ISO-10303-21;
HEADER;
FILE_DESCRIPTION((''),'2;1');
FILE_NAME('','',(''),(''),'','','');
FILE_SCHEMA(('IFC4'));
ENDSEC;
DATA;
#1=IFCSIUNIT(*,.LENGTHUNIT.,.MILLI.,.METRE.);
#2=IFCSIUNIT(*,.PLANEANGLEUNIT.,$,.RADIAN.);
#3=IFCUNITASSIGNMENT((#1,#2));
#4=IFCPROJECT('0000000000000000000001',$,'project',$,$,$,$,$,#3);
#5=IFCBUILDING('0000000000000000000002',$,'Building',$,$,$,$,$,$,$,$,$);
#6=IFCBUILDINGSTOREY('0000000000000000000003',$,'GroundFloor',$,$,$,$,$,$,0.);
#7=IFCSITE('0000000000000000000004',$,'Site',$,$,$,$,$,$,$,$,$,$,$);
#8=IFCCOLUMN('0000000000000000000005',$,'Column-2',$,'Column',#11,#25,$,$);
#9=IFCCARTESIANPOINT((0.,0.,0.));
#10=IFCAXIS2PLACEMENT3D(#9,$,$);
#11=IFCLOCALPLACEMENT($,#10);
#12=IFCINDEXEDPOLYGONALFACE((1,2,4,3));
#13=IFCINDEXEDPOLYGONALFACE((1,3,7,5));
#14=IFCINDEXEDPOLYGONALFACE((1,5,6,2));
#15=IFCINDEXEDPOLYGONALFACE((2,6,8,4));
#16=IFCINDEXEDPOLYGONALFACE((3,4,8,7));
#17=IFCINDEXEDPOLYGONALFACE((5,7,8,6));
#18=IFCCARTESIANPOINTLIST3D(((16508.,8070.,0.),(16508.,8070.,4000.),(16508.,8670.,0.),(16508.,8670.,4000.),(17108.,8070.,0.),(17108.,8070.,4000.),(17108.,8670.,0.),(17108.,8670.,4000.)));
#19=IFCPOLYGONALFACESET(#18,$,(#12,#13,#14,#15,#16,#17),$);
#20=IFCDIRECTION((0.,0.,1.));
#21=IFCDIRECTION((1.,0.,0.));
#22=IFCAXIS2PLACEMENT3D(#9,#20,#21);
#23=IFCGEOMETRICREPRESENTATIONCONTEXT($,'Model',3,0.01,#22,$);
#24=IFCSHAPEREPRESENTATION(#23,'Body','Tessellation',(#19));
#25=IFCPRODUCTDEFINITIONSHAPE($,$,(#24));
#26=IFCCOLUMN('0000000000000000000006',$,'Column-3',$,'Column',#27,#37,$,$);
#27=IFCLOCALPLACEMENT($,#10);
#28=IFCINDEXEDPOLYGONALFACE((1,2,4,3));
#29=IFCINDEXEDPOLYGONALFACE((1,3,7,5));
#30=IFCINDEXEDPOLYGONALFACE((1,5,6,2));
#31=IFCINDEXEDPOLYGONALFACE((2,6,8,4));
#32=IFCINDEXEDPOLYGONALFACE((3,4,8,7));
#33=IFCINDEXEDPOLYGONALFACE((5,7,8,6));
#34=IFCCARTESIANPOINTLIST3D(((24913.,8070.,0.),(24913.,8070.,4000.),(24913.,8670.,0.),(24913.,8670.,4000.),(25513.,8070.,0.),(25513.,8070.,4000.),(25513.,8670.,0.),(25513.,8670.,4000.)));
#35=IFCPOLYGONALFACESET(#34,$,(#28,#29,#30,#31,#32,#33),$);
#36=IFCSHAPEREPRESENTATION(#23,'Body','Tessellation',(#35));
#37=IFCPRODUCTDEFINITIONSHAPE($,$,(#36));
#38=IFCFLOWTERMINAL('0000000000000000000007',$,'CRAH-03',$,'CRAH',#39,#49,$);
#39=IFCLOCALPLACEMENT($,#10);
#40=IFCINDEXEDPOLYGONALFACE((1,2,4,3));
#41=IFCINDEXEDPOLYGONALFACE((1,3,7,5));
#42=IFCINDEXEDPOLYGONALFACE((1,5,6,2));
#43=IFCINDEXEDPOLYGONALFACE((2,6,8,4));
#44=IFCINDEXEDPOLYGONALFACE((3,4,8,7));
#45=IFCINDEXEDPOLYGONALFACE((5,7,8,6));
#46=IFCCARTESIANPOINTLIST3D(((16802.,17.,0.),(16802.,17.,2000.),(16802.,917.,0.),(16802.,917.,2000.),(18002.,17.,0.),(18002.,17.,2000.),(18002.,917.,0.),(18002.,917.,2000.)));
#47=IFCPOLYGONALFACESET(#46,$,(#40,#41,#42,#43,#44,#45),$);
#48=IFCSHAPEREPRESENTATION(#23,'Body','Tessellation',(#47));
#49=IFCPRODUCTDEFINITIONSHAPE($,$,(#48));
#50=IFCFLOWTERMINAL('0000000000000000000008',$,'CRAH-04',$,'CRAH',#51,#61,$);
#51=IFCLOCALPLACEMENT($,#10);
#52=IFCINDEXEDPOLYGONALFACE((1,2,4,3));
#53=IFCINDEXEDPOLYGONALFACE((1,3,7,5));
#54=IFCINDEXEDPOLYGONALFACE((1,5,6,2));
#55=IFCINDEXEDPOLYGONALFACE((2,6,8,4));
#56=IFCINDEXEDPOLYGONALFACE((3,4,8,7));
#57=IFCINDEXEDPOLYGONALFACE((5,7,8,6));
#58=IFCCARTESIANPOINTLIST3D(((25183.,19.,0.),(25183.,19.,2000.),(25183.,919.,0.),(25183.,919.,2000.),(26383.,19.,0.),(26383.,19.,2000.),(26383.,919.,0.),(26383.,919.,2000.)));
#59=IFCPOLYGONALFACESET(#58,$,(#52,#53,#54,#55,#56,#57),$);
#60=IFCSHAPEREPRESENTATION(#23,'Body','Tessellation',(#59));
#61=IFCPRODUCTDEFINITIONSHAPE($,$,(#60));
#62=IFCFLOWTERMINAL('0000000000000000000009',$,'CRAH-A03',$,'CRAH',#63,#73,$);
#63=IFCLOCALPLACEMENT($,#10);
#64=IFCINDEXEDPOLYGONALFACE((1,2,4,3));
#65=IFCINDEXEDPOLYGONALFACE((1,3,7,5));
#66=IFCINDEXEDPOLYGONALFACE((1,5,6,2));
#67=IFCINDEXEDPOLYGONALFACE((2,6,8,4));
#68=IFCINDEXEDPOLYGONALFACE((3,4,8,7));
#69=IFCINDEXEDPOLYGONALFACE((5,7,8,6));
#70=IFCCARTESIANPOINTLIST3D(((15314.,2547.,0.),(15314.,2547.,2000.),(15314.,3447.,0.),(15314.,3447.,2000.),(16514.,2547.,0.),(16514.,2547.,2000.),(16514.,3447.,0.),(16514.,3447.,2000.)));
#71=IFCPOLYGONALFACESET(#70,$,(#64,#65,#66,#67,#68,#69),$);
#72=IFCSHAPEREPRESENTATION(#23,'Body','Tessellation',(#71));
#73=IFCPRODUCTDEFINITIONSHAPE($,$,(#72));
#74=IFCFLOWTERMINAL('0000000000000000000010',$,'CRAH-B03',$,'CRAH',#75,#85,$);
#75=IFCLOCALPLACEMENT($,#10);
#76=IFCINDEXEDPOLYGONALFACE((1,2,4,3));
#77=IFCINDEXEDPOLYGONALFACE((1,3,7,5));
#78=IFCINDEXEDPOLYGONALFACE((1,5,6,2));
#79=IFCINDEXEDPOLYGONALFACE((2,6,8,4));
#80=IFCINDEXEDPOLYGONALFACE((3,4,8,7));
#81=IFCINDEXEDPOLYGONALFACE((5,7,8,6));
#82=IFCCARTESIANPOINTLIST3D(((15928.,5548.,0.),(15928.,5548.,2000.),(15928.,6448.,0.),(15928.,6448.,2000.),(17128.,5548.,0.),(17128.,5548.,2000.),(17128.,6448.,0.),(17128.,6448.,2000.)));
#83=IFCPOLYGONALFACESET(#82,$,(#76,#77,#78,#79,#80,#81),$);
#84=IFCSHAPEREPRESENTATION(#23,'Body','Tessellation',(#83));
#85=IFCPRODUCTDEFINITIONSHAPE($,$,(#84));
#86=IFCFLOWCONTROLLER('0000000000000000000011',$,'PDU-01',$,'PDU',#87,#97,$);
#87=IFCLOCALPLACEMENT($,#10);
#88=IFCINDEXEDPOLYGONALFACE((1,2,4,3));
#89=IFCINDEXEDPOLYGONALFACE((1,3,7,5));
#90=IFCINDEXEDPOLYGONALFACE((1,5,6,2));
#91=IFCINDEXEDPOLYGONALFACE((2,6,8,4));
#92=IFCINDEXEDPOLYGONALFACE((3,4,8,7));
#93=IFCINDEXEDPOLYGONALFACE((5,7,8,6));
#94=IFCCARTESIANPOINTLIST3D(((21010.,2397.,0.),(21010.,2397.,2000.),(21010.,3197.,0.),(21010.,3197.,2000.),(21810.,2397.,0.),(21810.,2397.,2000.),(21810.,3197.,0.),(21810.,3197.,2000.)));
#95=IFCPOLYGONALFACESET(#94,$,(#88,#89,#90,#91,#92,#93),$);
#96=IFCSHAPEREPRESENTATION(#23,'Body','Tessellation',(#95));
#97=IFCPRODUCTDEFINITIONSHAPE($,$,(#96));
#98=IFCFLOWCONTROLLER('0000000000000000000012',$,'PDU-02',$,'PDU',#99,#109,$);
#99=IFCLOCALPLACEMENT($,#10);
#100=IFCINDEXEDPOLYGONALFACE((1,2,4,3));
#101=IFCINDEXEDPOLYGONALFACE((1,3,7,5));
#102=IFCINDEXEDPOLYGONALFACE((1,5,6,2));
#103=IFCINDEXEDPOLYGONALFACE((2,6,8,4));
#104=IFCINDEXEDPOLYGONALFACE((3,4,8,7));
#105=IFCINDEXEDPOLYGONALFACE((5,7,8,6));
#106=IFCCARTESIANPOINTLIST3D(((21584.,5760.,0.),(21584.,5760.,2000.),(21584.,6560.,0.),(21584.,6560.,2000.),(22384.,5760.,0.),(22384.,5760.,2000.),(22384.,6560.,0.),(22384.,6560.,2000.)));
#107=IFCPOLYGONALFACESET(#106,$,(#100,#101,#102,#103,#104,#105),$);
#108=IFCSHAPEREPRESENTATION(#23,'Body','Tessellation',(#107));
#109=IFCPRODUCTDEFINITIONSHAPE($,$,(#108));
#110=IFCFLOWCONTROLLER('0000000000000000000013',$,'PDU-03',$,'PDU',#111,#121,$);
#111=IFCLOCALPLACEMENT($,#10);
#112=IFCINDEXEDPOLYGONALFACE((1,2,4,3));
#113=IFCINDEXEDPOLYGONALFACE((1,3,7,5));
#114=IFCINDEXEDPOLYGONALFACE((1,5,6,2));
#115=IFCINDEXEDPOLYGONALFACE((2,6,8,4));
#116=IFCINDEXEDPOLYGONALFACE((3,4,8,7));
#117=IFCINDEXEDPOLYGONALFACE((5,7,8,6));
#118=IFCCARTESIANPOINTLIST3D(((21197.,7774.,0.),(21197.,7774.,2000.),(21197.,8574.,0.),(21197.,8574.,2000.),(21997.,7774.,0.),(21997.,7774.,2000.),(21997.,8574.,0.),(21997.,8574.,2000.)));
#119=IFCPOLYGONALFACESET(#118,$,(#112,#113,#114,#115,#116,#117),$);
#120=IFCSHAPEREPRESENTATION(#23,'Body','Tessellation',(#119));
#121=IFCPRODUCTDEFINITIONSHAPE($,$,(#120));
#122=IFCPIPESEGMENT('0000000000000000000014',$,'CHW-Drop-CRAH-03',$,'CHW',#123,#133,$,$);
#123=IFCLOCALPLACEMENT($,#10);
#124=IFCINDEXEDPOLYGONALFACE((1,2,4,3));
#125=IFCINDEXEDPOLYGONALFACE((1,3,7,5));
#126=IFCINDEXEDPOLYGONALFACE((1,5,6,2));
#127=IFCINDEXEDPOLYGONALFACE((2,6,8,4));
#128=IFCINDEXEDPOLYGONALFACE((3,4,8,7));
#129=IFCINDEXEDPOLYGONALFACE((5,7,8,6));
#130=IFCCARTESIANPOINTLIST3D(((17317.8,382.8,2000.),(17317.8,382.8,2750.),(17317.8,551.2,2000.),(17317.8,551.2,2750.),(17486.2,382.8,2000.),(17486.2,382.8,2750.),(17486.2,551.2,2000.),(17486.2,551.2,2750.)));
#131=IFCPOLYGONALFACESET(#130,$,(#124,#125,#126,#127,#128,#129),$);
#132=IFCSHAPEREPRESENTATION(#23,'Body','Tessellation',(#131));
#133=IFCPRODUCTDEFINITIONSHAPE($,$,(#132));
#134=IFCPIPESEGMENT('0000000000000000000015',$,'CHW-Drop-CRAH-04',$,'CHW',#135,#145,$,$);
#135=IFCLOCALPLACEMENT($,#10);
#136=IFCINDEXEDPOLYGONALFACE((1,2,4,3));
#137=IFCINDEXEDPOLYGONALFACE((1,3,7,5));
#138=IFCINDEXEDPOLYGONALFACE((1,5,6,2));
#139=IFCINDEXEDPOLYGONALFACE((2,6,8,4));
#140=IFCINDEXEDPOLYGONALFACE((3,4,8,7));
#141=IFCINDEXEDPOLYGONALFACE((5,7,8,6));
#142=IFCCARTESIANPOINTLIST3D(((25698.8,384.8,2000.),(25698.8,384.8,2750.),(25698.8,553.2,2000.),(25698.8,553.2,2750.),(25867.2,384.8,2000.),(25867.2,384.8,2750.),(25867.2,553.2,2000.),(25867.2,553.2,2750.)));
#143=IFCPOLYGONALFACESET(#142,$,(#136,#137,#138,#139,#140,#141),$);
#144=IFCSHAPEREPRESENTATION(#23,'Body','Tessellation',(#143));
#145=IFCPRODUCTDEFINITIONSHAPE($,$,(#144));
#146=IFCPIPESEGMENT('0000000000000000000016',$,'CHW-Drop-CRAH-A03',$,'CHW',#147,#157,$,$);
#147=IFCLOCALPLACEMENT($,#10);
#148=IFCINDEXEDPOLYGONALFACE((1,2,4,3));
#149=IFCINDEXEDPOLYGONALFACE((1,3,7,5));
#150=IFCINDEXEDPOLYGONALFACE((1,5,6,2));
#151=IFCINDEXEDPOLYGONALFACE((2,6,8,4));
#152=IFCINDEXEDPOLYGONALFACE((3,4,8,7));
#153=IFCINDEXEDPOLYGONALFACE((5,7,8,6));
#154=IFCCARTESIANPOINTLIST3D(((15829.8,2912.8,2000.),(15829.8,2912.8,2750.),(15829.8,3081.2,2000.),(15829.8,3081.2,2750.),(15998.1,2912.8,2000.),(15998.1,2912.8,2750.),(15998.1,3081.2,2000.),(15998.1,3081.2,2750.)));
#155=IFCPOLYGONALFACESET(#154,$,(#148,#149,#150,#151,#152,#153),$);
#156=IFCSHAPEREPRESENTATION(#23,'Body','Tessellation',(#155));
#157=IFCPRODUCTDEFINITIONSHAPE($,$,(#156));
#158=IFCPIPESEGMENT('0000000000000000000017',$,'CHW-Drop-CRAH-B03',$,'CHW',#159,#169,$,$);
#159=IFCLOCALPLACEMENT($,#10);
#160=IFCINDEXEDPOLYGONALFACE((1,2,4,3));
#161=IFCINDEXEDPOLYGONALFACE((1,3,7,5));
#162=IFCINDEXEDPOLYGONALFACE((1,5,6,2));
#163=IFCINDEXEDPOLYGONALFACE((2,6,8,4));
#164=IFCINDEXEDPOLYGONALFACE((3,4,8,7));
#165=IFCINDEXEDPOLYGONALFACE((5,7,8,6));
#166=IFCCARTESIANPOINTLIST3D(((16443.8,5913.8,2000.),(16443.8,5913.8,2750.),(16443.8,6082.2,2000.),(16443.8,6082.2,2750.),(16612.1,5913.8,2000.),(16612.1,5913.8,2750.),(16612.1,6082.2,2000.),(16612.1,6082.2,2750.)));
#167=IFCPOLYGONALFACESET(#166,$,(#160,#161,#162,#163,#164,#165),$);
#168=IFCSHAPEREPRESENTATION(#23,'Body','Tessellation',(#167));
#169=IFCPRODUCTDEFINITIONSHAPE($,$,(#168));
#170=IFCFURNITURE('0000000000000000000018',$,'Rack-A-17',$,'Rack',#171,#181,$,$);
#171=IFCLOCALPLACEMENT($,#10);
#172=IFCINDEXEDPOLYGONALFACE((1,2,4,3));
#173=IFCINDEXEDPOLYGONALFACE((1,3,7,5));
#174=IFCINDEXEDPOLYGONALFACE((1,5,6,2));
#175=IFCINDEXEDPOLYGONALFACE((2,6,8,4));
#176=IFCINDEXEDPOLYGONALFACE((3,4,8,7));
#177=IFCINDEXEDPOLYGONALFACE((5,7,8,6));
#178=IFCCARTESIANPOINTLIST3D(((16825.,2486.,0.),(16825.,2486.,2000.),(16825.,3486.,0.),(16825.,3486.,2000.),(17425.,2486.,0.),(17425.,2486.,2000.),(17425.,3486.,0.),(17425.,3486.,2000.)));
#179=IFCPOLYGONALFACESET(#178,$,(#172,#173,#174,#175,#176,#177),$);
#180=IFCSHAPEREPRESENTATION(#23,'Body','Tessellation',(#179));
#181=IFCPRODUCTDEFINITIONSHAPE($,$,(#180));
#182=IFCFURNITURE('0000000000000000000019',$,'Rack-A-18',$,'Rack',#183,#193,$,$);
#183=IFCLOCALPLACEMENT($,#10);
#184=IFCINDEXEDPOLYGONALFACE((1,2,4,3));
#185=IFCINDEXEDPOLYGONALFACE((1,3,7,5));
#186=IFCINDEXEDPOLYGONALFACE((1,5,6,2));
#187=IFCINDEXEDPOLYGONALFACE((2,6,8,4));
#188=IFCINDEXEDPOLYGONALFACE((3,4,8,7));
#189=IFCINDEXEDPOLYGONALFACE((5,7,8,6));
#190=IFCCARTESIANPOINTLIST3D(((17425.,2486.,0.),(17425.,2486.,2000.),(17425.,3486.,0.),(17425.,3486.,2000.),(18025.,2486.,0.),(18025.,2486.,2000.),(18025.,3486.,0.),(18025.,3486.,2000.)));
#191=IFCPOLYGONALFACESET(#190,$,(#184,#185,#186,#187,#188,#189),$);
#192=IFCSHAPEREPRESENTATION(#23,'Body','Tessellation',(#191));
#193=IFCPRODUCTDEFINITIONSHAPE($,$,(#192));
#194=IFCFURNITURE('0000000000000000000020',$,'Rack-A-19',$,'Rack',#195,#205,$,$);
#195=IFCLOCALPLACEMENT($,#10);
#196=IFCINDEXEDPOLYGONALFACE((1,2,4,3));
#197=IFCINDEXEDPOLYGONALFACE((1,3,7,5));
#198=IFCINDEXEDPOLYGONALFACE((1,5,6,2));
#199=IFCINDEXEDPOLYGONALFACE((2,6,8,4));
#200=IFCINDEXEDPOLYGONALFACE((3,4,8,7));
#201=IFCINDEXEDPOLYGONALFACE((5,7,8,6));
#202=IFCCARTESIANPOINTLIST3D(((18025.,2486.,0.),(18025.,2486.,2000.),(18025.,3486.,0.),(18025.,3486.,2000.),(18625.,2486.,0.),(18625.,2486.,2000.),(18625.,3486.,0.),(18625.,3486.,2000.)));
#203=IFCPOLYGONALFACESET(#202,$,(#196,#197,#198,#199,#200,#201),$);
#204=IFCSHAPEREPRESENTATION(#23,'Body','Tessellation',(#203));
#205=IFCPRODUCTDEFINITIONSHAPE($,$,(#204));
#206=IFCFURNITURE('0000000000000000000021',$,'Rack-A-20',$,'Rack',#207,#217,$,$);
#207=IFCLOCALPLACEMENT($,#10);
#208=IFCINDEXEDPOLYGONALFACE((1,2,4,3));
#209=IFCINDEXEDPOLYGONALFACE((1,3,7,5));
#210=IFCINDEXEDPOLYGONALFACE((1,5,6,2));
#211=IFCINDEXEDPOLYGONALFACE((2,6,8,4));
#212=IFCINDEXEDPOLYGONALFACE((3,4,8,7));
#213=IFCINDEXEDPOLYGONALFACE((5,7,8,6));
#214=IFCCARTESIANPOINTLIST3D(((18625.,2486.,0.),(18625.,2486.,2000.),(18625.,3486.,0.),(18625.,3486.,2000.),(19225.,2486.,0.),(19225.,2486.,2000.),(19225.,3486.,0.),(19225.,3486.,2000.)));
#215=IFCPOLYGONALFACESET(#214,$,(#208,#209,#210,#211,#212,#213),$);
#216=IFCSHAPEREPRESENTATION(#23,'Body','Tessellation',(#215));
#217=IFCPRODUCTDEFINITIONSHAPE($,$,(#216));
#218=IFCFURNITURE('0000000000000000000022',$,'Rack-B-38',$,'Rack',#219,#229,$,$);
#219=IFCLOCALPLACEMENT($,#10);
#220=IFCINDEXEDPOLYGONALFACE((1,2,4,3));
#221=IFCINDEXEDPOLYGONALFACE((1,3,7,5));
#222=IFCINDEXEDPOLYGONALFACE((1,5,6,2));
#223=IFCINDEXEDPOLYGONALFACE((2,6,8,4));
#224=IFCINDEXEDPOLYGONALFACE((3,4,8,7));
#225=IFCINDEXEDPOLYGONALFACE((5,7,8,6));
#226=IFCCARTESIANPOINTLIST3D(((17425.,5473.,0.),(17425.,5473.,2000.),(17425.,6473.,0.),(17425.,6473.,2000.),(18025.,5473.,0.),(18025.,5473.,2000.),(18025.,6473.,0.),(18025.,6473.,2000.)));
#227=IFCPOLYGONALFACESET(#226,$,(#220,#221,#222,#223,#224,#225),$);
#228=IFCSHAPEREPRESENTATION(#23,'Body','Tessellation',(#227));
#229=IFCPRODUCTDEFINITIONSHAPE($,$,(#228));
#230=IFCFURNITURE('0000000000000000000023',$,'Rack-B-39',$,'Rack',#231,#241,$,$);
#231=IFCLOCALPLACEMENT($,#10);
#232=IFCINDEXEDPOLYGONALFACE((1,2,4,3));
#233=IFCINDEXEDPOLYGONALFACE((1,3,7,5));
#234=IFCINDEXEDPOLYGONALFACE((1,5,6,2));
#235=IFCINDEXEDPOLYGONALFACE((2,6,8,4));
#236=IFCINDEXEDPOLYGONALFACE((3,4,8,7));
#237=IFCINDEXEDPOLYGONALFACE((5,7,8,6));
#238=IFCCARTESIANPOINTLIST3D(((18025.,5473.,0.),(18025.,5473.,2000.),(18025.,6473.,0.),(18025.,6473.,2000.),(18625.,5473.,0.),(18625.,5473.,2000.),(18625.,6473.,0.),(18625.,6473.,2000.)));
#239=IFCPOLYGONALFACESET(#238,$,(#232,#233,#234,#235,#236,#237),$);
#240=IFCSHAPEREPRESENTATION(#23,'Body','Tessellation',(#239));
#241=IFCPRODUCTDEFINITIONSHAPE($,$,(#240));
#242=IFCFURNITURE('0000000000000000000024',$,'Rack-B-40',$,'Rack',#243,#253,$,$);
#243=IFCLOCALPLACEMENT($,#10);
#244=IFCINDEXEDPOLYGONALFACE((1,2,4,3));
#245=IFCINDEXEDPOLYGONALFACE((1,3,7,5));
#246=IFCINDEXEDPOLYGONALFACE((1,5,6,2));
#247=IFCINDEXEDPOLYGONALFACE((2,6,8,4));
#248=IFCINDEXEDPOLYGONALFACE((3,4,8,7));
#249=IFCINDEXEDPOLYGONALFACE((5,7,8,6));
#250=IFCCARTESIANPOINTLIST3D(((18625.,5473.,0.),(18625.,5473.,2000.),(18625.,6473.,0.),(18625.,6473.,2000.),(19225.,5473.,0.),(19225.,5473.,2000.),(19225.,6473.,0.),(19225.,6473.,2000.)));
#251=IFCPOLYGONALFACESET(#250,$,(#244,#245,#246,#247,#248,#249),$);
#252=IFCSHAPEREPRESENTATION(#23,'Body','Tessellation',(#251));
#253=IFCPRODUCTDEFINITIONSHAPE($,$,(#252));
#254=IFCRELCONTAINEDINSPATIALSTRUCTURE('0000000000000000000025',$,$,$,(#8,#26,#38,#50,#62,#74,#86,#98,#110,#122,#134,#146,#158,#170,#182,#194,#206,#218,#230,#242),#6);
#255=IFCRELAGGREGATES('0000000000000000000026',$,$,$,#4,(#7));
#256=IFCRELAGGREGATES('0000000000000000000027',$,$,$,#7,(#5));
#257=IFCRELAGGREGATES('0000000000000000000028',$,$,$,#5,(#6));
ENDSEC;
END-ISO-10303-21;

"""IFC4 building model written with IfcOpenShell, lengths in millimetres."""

from ifc_helpers import new_model, si_unit, frame, origin, origin_with_axes, origin_2d, place, context, project, spatial, rectangle, extrude, element, save


model = new_model("IFC4")

# Units and contexts
model_context = context("Model", 3, precision=0.01, world=origin_with_axes())
ifc_project = project(units=[si_unit("LENGTHUNIT", "METRE", prefix="MILLI"), si_unit("PLANEANGLEUNIT", "RADIAN")])

# Site, building, storey
site = spatial("IfcSite", under=ifc_project, Name="Site")
building = spatial("IfcBuilding", under=site, Name="Building")
storey = spatial("IfcBuildingStorey", under=building, Name="GroundFloor", Elevation=0.0)

# Columns
for number, where, z_axis, x_axis, name in (
    (1, (16808.0, 8370.0, 0.0), (0.0, 0.0, 1.0), (1.0, 0.0, 0.0), "Column-2"),
    (2, (25213.0, 8370.0, 0.0), (0.0, 0.0, 1.0), (1.0, 0.0, 0.0), "Column-3"),
):
    element("IfcColumn", number, at=place(None, frame(where, z_axis=z_axis, x_axis=x_axis)), inside=storey, Name=name, ObjectType="Column", context=model_context, shape_type="SweptSolid", body=[
        extrude(rectangle(XDim=600.0, YDim=600.0, at=origin_2d()), origin(), (0.0, 0.0, 1.0), 4000.0),
    ])

# Flow terminals
for number, where, z_axis, x_axis, name in (
    (3, (17402.0, 467.0, 0.0), (0.0, 0.0, 1.0), (1.0, 0.0, 0.0), "CRAH-03"),
    (4, (25783.0, 469.0, 0.0), (0.0, 0.0, 1.0), (1.0, 0.0, 0.0), "CRAH-04"),
    (5, (15914.0, 2997.0, 0.0), (0.0, 0.0, 1.0), (1.0, 0.0, 0.0), "CRAH-A03"),
    (6, (16528.0, 5998.0, 0.0), (0.0, 0.0, 1.0), (1.0, 0.0, 0.0), "CRAH-B03"),
):
    element("IfcFlowTerminal", number, at=place(None, frame(where, z_axis=z_axis, x_axis=x_axis)), inside=storey, Name=name, ObjectType="CRAH", context=model_context, shape_type="SweptSolid", body=[
        extrude(rectangle(XDim=1200.0, YDim=900.0, at=origin_2d()), origin(), (0.0, 0.0, 1.0), 2000.0),
    ])

# Flow controllers
for number, where, z_axis, x_axis, name in (
    (7, (21410.0, 2797.0, 0.0), (0.0, 0.0, 1.0), (1.0, 0.0, 0.0), "PDU-01"),
    (8, (21984.0, 6160.0, 0.0), (0.0, 0.0, 1.0), (1.0, 0.0, 0.0), "PDU-02"),
    (9, (21597.0, 8174.0, 0.0), (0.0, 0.0, 1.0), (1.0, 0.0, 0.0), "PDU-03"),
):
    element("IfcFlowController", number, at=place(None, frame(where, z_axis=z_axis, x_axis=x_axis)), inside=storey, Name=name, ObjectType="PDU", context=model_context, shape_type="SweptSolid", body=[
        extrude(rectangle(XDim=800.0, YDim=800.0, at=origin_2d()), origin(), (0.0, 0.0, 1.0), 2000.0),
    ])

# Pipe segments
for number, where, z_axis, x_axis, name in (
    (10, (17402.0, 467.0, 2000.0), (0.0, 0.0, 1.0), (1.0, 0.0, 0.0), "CHW-Drop-CRAH-03"),
    (11, (25783.0, 469.0, 2000.0), (0.0, 0.0, 1.0), (1.0, 0.0, 0.0), "CHW-Drop-CRAH-04"),
    (12, (15914.0, 2997.0, 2000.0), (0.0, 0.0, 1.0), (1.0, 0.0, 0.0), "CHW-Drop-CRAH-A03"),
    (13, (16528.0, 5998.0, 2000.0), (0.0, 0.0, 1.0), (1.0, 0.0, 0.0), "CHW-Drop-CRAH-B03"),
):
    element("IfcPipeSegment", number, at=place(None, frame(where, z_axis=z_axis, x_axis=x_axis)), inside=storey, Name=name, ObjectType="CHW", context=model_context, shape_type="SweptSolid", body=[
        extrude(rectangle(XDim=168.3, YDim=168.3, at=origin_2d()), origin(), (0.0, 0.0, 1.0), 750.0),
    ])

# Furniture
for number, where, z_axis, x_axis, name in (
    (14, (17125.0, 2986.0, 0.0), (0.0, 0.0, 1.0), (1.0, 0.0, 0.0), "Rack-A-17"),
    (15, (17725.0, 2986.0, 0.0), (0.0, 0.0, 1.0), (1.0, 0.0, 0.0), "Rack-A-18"),
    (16, (18325.0, 2986.0, 0.0), (0.0, 0.0, 1.0), (1.0, 0.0, 0.0), "Rack-A-19"),
    (17, (18925.0, 2986.0, 0.0), (0.0, 0.0, 1.0), (1.0, 0.0, 0.0), "Rack-A-20"),
    (18, (17725.0, 5973.0, 0.0), (0.0, 0.0, 1.0), (1.0, 0.0, 0.0), "Rack-B-38"),
    (19, (18325.0, 5973.0, 0.0), (0.0, 0.0, 1.0), (1.0, 0.0, 0.0), "Rack-B-39"),
    (20, (18925.0, 5973.0, 0.0), (0.0, 0.0, 1.0), (1.0, 0.0, 0.0), "Rack-B-40"),
):
    element("IfcFurniture", number, at=place(None, frame(where, z_axis=z_axis, x_axis=x_axis)), inside=storey, Name=name, ObjectType="Rack", context=model_context, shape_type="SweptSolid", body=[
        extrude(rectangle(XDim=600.0, YDim=1000.0, at=origin_2d()), origin(), (0.0, 0.0, 1.0), 2000.0),
    ])

save(model, "model.ifc")
